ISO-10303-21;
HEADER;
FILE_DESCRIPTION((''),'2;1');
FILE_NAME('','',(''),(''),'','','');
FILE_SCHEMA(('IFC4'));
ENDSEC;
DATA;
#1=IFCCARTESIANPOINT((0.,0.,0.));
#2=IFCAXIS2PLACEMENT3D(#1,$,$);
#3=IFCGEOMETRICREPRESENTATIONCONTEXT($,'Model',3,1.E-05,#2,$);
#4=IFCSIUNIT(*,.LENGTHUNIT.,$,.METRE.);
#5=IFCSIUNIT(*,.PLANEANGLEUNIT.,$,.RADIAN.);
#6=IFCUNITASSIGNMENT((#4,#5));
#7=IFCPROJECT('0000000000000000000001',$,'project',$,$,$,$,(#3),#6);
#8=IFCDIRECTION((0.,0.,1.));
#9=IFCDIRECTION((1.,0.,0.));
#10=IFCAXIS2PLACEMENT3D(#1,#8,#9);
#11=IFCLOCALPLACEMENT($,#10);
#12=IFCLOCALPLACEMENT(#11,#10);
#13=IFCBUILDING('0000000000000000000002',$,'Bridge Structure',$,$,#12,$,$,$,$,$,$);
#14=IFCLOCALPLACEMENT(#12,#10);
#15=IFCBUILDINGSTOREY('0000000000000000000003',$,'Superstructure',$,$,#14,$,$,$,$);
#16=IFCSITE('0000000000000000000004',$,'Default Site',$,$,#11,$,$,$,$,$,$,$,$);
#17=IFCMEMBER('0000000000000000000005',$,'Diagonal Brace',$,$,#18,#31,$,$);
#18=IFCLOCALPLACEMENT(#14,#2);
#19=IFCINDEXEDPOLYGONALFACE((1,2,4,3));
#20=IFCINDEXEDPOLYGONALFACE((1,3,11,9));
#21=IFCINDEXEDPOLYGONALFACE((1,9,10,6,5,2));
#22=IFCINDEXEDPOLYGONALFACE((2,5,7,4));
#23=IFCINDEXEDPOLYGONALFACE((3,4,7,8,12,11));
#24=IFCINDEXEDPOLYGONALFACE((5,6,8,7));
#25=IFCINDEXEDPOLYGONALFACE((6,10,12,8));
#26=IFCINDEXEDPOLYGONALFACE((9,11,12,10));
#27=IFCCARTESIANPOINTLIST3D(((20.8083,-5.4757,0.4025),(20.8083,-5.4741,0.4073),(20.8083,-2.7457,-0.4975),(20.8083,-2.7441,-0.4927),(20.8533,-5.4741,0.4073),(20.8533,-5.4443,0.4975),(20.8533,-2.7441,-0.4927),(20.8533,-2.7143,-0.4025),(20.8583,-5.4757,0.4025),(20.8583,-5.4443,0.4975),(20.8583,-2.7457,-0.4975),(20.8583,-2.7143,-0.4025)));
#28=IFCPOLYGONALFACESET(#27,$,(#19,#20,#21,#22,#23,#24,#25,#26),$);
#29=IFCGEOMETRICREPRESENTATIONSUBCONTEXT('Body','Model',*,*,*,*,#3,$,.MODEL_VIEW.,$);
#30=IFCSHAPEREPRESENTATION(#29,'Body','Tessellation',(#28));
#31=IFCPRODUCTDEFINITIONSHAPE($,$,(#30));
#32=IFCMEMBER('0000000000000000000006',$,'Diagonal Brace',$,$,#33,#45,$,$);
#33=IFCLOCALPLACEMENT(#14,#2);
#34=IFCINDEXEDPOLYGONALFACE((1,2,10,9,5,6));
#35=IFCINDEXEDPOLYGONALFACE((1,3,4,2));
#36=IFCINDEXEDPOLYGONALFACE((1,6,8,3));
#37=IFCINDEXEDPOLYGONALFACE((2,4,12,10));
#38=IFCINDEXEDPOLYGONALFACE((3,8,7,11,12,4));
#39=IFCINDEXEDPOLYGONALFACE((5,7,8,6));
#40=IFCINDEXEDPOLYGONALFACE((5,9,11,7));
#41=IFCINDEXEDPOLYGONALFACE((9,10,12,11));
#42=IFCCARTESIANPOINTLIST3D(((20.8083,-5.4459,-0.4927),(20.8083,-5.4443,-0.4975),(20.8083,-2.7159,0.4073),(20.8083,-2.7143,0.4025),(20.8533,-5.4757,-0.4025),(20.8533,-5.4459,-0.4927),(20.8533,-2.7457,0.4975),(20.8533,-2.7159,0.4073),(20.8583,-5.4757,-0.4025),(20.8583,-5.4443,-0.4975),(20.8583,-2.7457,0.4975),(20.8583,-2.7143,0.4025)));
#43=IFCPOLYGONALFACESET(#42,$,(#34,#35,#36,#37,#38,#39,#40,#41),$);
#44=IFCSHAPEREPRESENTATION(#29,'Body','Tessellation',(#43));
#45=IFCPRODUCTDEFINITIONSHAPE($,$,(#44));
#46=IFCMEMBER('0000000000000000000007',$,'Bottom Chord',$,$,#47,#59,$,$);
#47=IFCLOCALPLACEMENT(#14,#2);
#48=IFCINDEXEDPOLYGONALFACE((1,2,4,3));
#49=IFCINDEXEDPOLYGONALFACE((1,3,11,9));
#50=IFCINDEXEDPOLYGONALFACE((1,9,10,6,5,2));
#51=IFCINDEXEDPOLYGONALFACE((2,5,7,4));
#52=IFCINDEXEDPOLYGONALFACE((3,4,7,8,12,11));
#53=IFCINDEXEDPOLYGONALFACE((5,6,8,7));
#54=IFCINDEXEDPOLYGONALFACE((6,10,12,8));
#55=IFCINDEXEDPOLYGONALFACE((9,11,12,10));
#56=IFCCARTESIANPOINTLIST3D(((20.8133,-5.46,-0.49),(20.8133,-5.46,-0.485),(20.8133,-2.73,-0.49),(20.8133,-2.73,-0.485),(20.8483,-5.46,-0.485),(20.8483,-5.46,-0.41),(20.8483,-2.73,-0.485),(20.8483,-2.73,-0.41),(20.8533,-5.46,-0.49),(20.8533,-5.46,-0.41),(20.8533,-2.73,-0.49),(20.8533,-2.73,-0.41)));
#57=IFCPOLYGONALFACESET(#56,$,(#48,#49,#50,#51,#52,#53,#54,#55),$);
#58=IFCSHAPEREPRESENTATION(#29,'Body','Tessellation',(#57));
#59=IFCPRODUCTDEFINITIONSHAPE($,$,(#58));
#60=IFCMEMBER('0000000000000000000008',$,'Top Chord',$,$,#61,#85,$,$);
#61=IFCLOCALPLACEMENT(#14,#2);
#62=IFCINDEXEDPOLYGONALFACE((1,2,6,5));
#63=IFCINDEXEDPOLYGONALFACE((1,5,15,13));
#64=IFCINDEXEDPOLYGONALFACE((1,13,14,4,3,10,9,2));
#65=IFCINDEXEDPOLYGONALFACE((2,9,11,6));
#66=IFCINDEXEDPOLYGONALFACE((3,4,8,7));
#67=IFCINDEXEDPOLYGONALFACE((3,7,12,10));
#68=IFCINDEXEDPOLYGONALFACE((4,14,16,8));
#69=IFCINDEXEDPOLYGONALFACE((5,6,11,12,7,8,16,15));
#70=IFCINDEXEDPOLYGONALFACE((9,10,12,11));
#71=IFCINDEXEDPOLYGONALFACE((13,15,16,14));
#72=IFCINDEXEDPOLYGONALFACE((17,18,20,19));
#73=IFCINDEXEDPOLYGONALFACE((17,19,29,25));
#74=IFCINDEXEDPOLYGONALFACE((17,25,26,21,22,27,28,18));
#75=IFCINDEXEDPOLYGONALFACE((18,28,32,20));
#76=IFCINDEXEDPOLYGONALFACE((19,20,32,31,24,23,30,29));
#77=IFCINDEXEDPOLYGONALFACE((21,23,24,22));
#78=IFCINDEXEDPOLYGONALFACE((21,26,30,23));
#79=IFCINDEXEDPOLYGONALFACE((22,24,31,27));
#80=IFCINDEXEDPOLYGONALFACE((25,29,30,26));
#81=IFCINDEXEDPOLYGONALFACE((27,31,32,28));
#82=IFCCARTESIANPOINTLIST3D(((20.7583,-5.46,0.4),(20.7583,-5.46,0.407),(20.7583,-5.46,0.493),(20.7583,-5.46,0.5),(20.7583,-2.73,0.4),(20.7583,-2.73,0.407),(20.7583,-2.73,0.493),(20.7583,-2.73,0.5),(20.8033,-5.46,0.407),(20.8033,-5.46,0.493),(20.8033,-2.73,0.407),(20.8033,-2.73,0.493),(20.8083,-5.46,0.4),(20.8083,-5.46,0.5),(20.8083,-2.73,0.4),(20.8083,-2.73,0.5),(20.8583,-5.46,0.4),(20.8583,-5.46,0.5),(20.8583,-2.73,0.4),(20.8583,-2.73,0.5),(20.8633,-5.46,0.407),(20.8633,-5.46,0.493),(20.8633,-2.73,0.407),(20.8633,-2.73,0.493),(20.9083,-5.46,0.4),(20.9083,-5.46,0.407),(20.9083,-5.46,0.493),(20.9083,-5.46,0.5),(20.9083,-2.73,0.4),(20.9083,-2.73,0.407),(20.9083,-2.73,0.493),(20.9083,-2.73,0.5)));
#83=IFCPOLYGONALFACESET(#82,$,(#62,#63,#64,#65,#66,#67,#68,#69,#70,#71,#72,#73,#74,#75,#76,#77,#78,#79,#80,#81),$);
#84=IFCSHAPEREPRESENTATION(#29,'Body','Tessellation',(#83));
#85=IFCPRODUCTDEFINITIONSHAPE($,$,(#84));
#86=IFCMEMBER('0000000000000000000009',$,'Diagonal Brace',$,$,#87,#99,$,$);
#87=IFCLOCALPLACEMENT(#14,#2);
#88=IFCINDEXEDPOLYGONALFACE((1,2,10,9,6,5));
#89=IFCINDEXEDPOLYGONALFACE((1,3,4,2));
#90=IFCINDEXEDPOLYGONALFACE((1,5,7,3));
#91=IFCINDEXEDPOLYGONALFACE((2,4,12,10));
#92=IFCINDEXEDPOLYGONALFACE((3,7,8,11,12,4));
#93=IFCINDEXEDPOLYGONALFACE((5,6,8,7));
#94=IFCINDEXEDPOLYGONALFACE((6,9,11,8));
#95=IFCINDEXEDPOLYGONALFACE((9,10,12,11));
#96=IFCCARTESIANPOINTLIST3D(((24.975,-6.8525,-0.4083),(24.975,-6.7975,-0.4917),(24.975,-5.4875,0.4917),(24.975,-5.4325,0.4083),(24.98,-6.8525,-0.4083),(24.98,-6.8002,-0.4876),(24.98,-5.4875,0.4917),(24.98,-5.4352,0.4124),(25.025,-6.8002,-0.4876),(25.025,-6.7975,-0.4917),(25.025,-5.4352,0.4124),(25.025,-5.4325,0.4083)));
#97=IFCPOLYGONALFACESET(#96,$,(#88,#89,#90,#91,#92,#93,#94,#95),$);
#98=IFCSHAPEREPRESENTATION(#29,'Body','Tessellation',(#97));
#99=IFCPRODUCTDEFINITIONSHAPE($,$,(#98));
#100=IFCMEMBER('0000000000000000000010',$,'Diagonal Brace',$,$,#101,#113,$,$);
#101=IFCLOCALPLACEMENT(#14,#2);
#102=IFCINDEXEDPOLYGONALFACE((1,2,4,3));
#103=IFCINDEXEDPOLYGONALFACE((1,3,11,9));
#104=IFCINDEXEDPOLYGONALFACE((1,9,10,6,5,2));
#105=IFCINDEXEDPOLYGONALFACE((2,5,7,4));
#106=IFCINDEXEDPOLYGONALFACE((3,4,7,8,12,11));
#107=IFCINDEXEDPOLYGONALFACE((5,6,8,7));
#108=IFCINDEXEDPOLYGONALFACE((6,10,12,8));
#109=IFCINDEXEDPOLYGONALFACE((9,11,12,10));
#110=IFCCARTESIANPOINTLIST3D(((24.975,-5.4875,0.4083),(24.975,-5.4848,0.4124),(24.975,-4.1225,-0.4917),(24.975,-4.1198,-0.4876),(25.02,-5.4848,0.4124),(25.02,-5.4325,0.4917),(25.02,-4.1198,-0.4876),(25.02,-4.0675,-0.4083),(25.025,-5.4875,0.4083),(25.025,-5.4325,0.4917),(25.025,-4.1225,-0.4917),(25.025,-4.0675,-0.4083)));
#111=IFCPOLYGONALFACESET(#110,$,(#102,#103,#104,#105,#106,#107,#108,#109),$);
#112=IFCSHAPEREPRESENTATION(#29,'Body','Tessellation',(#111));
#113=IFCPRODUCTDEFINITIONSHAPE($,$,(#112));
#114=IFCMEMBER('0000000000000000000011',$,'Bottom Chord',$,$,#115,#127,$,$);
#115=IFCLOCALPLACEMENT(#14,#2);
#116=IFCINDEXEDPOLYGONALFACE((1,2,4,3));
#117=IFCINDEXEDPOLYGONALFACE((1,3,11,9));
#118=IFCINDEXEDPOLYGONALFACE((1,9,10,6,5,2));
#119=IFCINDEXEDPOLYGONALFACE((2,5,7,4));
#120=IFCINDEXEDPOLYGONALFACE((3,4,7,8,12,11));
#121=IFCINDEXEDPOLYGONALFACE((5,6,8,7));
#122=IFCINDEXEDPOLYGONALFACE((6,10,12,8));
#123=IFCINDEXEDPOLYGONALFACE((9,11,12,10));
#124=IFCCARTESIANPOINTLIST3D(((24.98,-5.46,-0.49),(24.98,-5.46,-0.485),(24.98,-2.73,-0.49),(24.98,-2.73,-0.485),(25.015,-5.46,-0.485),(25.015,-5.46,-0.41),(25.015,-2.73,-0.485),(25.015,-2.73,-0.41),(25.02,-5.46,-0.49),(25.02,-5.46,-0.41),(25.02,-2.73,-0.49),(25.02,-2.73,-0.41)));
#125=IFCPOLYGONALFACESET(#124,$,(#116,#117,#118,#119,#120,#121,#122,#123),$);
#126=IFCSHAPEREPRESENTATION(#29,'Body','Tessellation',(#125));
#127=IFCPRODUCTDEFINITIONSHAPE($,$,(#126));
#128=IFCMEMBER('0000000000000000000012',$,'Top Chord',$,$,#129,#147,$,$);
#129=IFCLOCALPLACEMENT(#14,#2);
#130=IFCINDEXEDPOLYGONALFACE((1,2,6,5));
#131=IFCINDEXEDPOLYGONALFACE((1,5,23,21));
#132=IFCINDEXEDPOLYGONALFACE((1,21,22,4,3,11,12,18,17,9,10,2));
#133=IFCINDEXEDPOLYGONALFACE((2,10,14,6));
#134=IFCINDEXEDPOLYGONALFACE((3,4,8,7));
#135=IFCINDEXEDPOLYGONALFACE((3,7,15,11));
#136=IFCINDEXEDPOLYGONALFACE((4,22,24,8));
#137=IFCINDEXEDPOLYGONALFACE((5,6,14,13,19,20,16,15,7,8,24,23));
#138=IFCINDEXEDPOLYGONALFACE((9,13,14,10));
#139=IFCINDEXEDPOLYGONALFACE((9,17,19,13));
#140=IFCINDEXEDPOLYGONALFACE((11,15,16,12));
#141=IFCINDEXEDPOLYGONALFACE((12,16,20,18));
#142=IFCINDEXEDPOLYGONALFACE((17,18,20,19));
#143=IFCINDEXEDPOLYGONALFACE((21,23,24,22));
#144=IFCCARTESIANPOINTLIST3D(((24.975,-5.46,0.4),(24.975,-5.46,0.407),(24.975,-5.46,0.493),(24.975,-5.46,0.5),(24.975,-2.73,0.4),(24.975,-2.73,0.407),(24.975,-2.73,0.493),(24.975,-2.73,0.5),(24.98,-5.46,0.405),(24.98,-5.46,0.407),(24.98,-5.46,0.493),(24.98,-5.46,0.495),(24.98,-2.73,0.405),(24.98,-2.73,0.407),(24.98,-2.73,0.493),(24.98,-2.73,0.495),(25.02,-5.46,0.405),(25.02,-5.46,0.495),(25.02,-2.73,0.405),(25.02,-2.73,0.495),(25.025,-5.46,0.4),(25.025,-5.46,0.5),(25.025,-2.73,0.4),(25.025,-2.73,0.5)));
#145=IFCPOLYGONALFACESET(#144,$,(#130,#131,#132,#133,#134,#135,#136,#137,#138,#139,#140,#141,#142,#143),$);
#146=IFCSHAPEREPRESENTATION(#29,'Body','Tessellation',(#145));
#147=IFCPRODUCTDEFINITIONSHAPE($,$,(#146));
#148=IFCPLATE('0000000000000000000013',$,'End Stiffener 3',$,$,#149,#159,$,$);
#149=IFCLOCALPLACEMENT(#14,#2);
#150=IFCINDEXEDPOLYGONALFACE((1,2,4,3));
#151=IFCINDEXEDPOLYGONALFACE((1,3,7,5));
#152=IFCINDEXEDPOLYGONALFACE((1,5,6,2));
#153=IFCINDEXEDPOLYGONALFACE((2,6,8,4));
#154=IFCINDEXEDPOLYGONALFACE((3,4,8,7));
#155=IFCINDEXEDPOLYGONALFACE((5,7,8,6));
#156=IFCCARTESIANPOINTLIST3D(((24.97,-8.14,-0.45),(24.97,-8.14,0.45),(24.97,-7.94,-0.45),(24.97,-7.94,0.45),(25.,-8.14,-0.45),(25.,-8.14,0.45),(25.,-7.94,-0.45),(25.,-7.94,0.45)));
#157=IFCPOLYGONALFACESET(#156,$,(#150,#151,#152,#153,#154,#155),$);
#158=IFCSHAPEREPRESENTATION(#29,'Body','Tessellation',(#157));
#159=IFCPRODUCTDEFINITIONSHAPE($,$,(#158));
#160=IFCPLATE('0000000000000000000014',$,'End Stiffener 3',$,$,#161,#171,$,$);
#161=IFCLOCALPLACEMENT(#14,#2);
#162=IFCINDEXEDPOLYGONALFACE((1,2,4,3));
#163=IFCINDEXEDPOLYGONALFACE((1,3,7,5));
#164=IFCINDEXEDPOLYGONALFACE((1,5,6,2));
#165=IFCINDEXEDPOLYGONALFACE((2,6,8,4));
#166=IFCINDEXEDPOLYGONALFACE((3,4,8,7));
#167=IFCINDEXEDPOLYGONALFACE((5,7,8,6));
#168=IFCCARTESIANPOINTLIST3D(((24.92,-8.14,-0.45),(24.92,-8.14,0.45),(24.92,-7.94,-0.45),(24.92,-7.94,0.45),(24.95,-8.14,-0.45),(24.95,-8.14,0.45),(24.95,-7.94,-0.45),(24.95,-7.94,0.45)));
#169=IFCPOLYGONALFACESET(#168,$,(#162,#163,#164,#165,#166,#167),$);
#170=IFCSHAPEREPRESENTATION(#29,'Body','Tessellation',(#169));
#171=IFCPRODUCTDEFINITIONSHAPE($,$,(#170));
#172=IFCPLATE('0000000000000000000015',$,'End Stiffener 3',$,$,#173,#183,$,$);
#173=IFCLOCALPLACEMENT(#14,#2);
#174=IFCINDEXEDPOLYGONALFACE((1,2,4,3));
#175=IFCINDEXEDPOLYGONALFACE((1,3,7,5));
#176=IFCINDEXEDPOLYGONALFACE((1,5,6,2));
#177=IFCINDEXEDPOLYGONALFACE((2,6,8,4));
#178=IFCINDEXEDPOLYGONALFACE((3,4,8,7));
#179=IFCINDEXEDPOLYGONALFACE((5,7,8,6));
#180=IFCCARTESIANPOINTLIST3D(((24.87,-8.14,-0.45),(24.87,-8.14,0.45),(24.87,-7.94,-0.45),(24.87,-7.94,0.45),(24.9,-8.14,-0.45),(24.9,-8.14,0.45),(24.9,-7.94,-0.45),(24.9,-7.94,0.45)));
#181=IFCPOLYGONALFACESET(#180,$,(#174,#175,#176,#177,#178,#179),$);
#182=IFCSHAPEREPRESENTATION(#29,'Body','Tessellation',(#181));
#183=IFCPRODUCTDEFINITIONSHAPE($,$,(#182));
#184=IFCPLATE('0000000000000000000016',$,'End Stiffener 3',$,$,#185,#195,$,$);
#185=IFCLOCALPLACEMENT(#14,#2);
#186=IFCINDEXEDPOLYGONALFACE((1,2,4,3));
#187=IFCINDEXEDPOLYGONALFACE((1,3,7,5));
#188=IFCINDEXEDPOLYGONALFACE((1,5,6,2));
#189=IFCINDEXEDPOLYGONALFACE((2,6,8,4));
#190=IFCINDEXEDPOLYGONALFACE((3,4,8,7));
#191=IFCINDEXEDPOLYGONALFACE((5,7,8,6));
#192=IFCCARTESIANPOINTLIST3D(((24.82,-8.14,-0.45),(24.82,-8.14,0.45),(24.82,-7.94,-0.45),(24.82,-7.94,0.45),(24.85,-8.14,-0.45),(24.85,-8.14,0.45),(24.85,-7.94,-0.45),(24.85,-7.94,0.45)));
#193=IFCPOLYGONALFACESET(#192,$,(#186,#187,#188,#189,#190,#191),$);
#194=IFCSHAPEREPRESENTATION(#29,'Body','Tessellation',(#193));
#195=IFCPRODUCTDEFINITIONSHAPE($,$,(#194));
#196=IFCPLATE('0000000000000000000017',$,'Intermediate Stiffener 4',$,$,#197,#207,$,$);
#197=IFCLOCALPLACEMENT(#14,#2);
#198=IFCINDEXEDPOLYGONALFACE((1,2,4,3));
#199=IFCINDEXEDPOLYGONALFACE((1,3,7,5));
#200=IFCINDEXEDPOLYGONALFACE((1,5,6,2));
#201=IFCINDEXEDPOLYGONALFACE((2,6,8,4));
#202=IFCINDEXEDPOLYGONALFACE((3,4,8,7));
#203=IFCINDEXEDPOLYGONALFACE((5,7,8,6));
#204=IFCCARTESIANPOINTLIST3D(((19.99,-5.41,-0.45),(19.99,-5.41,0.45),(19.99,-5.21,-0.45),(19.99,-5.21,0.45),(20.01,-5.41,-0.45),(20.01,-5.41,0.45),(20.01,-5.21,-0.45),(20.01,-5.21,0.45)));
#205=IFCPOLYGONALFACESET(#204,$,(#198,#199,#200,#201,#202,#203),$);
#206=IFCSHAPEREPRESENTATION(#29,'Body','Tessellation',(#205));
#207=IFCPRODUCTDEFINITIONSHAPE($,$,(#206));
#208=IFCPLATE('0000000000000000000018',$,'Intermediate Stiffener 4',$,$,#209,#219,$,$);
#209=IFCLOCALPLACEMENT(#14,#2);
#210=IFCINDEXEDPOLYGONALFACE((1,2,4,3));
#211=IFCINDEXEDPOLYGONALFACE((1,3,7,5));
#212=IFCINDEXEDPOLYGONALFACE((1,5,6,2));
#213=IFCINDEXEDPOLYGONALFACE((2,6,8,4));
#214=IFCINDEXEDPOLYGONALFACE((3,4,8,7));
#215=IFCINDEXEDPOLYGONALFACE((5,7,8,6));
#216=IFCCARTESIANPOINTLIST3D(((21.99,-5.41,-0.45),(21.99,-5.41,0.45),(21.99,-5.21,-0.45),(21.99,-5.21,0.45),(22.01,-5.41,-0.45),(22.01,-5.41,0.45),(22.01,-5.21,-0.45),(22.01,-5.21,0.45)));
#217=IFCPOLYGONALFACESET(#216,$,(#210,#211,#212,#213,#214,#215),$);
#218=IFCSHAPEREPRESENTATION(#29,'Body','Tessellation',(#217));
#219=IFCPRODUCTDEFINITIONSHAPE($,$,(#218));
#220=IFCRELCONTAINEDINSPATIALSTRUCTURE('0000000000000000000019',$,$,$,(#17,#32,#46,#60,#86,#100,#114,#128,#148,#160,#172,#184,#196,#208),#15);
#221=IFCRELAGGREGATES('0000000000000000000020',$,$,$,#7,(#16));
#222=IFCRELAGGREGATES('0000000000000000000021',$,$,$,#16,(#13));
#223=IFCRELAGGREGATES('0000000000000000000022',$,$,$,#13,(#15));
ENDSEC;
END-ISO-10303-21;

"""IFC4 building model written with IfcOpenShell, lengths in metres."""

from ifc_helpers import new_model, si_unit, frame, origin, origin_with_axes, origin_2d_with_axis, place, context, subcontext, project, spatial, polyline, rectangle, l_section, c_section, outline, composite_profile, extrude, element, save


model = new_model("IFC4")

# Units and contexts
model_context = context("Model", 3, precision=1e-05, world=origin())
body_context = subcontext(model_context, "Body", "Model", "MODEL_VIEW")
ifc_project = project(units=[si_unit("LENGTHUNIT", "METRE"), si_unit("PLANEANGLEUNIT", "RADIAN")], contexts=[model_context])

# Site, building, storey
site_placement = place(None, origin_with_axes())
site = spatial("IfcSite", under=ifc_project, at=site_placement, Name="Default Site")
building_placement = place(site_placement, origin_with_axes())
building = spatial("IfcBuilding", under=site, at=building_placement, Name="Bridge Structure")
storey_placement = place(building_placement, origin_with_axes())
storey = spatial("IfcBuildingStorey", under=building, at=storey_placement, Name="Superstructure")

# Members
for number, where, z_axis, x_axis, name in (
    (1, (20.8333, -5.46, 0.45), (0.0, 0.949722, -0.313095), (-1.0, 0.0, 0.0), "Diagonal Brace"),
    (2, (20.8333, -5.46, -0.45), (0.0, 0.949722, 0.313095), (-1.0, 0.0, 0.0), "Diagonal Brace"),
):
    element("IfcMember", number, at=place(storey_placement, frame(where, z_axis=z_axis, x_axis=x_axis)), inside=storey, Name=name, context=body_context, shape_type="SweptSolid", body=[
        extrude(l_section(Depth=0.1, Width=0.05, Thickness=0.005, at=origin_2d_with_axis()), origin_with_axes(), (0.0, 0.0, 1.0), 2.8745),
    ])
member_1_placement = place(storey_placement, frame((20.8333, -5.46, -0.45), z_axis=(0.0, 1.0, 0.0), x_axis=(-1.0, 0.0, 0.0)))
element("IfcMember", 3, at=member_1_placement, inside=storey, Name="Bottom Chord", context=body_context, shape_type="SweptSolid", body=[
    extrude(l_section(Depth=0.08, Width=0.04, Thickness=0.005, at=origin_2d_with_axis()), origin_with_axes(), (0.0, 0.0, 1.0), 2.73),
])
member_2_placement = place(storey_placement, frame((20.8333, -5.46, 0.45), z_axis=(0.0, 1.0, 0.0), x_axis=(-1.0, 0.0, 0.0)))
element("IfcMember", 4, at=member_2_placement, inside=storey, Name="Top Chord", context=body_context, shape_type="SweptSolid", body=[
    extrude(composite_profile([outline(polyline([(-0.025, -0.05), (-0.025, 0.05), (-0.075, 0.05), (-0.075, 0.043), (-0.03, 0.043), (-0.03, -0.043), (-0.075, -0.043), (-0.075, -0.05), (-0.025, -0.05)])), outline(polyline([(0.025, -0.05), (0.075, -0.05), (0.075, -0.043), (0.03, -0.043), (0.03, 0.043), (0.075, 0.043), (0.075, 0.05), (0.025, 0.05), (0.025, -0.05)]))]), origin_with_axes(), (0.0, 0.0, 1.0), 2.73),
])
for number, where, z_axis, x_axis, name in (
    (5, (25.0, -5.46, 0.45), (0.0, -0.834862, -0.550459), (1.0, 0.0, 0.0), "Diagonal Brace"),
    (6, (25.0, -5.46, 0.45), (0.0, 0.834862, -0.550459), (-1.0, 0.0, 0.0), "Diagonal Brace"),
):
    element("IfcMember", number, at=place(storey_placement, frame(where, z_axis=z_axis, x_axis=x_axis)), inside=storey, Name=name, context=body_context, shape_type="SweptSolid", body=[
        extrude(l_section(Depth=0.1, Width=0.05, Thickness=0.005, at=origin_2d_with_axis()), origin_with_axes(), (0.0, 0.0, 1.0), 1.635),
    ])
member_3_placement = place(storey_placement, frame((25.0, -5.46, -0.45), z_axis=(0.0, 1.0, 0.0), x_axis=(-1.0, 0.0, 0.0)))
element("IfcMember", 7, at=member_3_placement, inside=storey, Name="Bottom Chord", context=body_context, shape_type="SweptSolid", body=[
    extrude(l_section(Depth=0.08, Width=0.04, Thickness=0.005, at=origin_2d_with_axis()), origin_with_axes(), (0.0, 0.0, 1.0), 2.73),
])
member_4_placement = place(storey_placement, frame((25.0, -5.46, 0.45), z_axis=(0.0, 1.0, 0.0), x_axis=(-1.0, 0.0, 0.0)))
element("IfcMember", 8, at=member_4_placement, inside=storey, Name="Top Chord", context=body_context, shape_type="SweptSolid", body=[
    extrude(c_section(Depth=0.1, Width=0.05, WallThickness=0.005, Girth=0.007, at=origin_2d_with_axis()), origin_with_axes(), (0.0, 0.0, 1.0), 2.73),
])

# Plates
for number, where, z_axis, x_axis, name in (
    (9, (24.985, -8.04, -0.45), (0.0, 0.0, 1.0), (1.0, 0.0, 0.0), "End Stiffener 3"),
    (10, (24.935, -8.04, -0.45), (0.0, 0.0, 1.0), (1.0, 0.0, 0.0), "End Stiffener 3"),
    (11, (24.885, -8.04, -0.45), (0.0, 0.0, 1.0), (1.0, 0.0, 0.0), "End Stiffener 3"),
    (12, (24.835, -8.04, -0.45), (0.0, 0.0, 1.0), (1.0, 0.0, 0.0), "End Stiffener 3"),
):
    element("IfcPlate", number, at=place(storey_placement, frame(where, z_axis=z_axis, x_axis=x_axis)), inside=storey, Name=name, context=body_context, shape_type="SweptSolid", body=[
        extrude(rectangle(XDim=0.03, YDim=0.2, at=origin_2d_with_axis()), origin_with_axes(), (0.0, 0.0, 1.0), 0.9),
    ])
for number, where, z_axis, x_axis, name in (
    (13, (20.0, -5.31, -0.45), (0.0, 0.0, 1.0), (1.0, 0.0, 0.0), "Intermediate Stiffener 4"),
    (14, (22.0, -5.31, -0.45), (0.0, 0.0, 1.0), (1.0, 0.0, 0.0), "Intermediate Stiffener 4"),
):
    element("IfcPlate", number, at=place(storey_placement, frame(where, z_axis=z_axis, x_axis=x_axis)), inside=storey, Name=name, context=body_context, shape_type="SweptSolid", body=[
        extrude(rectangle(XDim=0.02, YDim=0.2, at=origin_2d_with_axis()), origin_with_axes(), (0.0, 0.0, 1.0), 0.9),
    ])

save(model, "model.ifc")
